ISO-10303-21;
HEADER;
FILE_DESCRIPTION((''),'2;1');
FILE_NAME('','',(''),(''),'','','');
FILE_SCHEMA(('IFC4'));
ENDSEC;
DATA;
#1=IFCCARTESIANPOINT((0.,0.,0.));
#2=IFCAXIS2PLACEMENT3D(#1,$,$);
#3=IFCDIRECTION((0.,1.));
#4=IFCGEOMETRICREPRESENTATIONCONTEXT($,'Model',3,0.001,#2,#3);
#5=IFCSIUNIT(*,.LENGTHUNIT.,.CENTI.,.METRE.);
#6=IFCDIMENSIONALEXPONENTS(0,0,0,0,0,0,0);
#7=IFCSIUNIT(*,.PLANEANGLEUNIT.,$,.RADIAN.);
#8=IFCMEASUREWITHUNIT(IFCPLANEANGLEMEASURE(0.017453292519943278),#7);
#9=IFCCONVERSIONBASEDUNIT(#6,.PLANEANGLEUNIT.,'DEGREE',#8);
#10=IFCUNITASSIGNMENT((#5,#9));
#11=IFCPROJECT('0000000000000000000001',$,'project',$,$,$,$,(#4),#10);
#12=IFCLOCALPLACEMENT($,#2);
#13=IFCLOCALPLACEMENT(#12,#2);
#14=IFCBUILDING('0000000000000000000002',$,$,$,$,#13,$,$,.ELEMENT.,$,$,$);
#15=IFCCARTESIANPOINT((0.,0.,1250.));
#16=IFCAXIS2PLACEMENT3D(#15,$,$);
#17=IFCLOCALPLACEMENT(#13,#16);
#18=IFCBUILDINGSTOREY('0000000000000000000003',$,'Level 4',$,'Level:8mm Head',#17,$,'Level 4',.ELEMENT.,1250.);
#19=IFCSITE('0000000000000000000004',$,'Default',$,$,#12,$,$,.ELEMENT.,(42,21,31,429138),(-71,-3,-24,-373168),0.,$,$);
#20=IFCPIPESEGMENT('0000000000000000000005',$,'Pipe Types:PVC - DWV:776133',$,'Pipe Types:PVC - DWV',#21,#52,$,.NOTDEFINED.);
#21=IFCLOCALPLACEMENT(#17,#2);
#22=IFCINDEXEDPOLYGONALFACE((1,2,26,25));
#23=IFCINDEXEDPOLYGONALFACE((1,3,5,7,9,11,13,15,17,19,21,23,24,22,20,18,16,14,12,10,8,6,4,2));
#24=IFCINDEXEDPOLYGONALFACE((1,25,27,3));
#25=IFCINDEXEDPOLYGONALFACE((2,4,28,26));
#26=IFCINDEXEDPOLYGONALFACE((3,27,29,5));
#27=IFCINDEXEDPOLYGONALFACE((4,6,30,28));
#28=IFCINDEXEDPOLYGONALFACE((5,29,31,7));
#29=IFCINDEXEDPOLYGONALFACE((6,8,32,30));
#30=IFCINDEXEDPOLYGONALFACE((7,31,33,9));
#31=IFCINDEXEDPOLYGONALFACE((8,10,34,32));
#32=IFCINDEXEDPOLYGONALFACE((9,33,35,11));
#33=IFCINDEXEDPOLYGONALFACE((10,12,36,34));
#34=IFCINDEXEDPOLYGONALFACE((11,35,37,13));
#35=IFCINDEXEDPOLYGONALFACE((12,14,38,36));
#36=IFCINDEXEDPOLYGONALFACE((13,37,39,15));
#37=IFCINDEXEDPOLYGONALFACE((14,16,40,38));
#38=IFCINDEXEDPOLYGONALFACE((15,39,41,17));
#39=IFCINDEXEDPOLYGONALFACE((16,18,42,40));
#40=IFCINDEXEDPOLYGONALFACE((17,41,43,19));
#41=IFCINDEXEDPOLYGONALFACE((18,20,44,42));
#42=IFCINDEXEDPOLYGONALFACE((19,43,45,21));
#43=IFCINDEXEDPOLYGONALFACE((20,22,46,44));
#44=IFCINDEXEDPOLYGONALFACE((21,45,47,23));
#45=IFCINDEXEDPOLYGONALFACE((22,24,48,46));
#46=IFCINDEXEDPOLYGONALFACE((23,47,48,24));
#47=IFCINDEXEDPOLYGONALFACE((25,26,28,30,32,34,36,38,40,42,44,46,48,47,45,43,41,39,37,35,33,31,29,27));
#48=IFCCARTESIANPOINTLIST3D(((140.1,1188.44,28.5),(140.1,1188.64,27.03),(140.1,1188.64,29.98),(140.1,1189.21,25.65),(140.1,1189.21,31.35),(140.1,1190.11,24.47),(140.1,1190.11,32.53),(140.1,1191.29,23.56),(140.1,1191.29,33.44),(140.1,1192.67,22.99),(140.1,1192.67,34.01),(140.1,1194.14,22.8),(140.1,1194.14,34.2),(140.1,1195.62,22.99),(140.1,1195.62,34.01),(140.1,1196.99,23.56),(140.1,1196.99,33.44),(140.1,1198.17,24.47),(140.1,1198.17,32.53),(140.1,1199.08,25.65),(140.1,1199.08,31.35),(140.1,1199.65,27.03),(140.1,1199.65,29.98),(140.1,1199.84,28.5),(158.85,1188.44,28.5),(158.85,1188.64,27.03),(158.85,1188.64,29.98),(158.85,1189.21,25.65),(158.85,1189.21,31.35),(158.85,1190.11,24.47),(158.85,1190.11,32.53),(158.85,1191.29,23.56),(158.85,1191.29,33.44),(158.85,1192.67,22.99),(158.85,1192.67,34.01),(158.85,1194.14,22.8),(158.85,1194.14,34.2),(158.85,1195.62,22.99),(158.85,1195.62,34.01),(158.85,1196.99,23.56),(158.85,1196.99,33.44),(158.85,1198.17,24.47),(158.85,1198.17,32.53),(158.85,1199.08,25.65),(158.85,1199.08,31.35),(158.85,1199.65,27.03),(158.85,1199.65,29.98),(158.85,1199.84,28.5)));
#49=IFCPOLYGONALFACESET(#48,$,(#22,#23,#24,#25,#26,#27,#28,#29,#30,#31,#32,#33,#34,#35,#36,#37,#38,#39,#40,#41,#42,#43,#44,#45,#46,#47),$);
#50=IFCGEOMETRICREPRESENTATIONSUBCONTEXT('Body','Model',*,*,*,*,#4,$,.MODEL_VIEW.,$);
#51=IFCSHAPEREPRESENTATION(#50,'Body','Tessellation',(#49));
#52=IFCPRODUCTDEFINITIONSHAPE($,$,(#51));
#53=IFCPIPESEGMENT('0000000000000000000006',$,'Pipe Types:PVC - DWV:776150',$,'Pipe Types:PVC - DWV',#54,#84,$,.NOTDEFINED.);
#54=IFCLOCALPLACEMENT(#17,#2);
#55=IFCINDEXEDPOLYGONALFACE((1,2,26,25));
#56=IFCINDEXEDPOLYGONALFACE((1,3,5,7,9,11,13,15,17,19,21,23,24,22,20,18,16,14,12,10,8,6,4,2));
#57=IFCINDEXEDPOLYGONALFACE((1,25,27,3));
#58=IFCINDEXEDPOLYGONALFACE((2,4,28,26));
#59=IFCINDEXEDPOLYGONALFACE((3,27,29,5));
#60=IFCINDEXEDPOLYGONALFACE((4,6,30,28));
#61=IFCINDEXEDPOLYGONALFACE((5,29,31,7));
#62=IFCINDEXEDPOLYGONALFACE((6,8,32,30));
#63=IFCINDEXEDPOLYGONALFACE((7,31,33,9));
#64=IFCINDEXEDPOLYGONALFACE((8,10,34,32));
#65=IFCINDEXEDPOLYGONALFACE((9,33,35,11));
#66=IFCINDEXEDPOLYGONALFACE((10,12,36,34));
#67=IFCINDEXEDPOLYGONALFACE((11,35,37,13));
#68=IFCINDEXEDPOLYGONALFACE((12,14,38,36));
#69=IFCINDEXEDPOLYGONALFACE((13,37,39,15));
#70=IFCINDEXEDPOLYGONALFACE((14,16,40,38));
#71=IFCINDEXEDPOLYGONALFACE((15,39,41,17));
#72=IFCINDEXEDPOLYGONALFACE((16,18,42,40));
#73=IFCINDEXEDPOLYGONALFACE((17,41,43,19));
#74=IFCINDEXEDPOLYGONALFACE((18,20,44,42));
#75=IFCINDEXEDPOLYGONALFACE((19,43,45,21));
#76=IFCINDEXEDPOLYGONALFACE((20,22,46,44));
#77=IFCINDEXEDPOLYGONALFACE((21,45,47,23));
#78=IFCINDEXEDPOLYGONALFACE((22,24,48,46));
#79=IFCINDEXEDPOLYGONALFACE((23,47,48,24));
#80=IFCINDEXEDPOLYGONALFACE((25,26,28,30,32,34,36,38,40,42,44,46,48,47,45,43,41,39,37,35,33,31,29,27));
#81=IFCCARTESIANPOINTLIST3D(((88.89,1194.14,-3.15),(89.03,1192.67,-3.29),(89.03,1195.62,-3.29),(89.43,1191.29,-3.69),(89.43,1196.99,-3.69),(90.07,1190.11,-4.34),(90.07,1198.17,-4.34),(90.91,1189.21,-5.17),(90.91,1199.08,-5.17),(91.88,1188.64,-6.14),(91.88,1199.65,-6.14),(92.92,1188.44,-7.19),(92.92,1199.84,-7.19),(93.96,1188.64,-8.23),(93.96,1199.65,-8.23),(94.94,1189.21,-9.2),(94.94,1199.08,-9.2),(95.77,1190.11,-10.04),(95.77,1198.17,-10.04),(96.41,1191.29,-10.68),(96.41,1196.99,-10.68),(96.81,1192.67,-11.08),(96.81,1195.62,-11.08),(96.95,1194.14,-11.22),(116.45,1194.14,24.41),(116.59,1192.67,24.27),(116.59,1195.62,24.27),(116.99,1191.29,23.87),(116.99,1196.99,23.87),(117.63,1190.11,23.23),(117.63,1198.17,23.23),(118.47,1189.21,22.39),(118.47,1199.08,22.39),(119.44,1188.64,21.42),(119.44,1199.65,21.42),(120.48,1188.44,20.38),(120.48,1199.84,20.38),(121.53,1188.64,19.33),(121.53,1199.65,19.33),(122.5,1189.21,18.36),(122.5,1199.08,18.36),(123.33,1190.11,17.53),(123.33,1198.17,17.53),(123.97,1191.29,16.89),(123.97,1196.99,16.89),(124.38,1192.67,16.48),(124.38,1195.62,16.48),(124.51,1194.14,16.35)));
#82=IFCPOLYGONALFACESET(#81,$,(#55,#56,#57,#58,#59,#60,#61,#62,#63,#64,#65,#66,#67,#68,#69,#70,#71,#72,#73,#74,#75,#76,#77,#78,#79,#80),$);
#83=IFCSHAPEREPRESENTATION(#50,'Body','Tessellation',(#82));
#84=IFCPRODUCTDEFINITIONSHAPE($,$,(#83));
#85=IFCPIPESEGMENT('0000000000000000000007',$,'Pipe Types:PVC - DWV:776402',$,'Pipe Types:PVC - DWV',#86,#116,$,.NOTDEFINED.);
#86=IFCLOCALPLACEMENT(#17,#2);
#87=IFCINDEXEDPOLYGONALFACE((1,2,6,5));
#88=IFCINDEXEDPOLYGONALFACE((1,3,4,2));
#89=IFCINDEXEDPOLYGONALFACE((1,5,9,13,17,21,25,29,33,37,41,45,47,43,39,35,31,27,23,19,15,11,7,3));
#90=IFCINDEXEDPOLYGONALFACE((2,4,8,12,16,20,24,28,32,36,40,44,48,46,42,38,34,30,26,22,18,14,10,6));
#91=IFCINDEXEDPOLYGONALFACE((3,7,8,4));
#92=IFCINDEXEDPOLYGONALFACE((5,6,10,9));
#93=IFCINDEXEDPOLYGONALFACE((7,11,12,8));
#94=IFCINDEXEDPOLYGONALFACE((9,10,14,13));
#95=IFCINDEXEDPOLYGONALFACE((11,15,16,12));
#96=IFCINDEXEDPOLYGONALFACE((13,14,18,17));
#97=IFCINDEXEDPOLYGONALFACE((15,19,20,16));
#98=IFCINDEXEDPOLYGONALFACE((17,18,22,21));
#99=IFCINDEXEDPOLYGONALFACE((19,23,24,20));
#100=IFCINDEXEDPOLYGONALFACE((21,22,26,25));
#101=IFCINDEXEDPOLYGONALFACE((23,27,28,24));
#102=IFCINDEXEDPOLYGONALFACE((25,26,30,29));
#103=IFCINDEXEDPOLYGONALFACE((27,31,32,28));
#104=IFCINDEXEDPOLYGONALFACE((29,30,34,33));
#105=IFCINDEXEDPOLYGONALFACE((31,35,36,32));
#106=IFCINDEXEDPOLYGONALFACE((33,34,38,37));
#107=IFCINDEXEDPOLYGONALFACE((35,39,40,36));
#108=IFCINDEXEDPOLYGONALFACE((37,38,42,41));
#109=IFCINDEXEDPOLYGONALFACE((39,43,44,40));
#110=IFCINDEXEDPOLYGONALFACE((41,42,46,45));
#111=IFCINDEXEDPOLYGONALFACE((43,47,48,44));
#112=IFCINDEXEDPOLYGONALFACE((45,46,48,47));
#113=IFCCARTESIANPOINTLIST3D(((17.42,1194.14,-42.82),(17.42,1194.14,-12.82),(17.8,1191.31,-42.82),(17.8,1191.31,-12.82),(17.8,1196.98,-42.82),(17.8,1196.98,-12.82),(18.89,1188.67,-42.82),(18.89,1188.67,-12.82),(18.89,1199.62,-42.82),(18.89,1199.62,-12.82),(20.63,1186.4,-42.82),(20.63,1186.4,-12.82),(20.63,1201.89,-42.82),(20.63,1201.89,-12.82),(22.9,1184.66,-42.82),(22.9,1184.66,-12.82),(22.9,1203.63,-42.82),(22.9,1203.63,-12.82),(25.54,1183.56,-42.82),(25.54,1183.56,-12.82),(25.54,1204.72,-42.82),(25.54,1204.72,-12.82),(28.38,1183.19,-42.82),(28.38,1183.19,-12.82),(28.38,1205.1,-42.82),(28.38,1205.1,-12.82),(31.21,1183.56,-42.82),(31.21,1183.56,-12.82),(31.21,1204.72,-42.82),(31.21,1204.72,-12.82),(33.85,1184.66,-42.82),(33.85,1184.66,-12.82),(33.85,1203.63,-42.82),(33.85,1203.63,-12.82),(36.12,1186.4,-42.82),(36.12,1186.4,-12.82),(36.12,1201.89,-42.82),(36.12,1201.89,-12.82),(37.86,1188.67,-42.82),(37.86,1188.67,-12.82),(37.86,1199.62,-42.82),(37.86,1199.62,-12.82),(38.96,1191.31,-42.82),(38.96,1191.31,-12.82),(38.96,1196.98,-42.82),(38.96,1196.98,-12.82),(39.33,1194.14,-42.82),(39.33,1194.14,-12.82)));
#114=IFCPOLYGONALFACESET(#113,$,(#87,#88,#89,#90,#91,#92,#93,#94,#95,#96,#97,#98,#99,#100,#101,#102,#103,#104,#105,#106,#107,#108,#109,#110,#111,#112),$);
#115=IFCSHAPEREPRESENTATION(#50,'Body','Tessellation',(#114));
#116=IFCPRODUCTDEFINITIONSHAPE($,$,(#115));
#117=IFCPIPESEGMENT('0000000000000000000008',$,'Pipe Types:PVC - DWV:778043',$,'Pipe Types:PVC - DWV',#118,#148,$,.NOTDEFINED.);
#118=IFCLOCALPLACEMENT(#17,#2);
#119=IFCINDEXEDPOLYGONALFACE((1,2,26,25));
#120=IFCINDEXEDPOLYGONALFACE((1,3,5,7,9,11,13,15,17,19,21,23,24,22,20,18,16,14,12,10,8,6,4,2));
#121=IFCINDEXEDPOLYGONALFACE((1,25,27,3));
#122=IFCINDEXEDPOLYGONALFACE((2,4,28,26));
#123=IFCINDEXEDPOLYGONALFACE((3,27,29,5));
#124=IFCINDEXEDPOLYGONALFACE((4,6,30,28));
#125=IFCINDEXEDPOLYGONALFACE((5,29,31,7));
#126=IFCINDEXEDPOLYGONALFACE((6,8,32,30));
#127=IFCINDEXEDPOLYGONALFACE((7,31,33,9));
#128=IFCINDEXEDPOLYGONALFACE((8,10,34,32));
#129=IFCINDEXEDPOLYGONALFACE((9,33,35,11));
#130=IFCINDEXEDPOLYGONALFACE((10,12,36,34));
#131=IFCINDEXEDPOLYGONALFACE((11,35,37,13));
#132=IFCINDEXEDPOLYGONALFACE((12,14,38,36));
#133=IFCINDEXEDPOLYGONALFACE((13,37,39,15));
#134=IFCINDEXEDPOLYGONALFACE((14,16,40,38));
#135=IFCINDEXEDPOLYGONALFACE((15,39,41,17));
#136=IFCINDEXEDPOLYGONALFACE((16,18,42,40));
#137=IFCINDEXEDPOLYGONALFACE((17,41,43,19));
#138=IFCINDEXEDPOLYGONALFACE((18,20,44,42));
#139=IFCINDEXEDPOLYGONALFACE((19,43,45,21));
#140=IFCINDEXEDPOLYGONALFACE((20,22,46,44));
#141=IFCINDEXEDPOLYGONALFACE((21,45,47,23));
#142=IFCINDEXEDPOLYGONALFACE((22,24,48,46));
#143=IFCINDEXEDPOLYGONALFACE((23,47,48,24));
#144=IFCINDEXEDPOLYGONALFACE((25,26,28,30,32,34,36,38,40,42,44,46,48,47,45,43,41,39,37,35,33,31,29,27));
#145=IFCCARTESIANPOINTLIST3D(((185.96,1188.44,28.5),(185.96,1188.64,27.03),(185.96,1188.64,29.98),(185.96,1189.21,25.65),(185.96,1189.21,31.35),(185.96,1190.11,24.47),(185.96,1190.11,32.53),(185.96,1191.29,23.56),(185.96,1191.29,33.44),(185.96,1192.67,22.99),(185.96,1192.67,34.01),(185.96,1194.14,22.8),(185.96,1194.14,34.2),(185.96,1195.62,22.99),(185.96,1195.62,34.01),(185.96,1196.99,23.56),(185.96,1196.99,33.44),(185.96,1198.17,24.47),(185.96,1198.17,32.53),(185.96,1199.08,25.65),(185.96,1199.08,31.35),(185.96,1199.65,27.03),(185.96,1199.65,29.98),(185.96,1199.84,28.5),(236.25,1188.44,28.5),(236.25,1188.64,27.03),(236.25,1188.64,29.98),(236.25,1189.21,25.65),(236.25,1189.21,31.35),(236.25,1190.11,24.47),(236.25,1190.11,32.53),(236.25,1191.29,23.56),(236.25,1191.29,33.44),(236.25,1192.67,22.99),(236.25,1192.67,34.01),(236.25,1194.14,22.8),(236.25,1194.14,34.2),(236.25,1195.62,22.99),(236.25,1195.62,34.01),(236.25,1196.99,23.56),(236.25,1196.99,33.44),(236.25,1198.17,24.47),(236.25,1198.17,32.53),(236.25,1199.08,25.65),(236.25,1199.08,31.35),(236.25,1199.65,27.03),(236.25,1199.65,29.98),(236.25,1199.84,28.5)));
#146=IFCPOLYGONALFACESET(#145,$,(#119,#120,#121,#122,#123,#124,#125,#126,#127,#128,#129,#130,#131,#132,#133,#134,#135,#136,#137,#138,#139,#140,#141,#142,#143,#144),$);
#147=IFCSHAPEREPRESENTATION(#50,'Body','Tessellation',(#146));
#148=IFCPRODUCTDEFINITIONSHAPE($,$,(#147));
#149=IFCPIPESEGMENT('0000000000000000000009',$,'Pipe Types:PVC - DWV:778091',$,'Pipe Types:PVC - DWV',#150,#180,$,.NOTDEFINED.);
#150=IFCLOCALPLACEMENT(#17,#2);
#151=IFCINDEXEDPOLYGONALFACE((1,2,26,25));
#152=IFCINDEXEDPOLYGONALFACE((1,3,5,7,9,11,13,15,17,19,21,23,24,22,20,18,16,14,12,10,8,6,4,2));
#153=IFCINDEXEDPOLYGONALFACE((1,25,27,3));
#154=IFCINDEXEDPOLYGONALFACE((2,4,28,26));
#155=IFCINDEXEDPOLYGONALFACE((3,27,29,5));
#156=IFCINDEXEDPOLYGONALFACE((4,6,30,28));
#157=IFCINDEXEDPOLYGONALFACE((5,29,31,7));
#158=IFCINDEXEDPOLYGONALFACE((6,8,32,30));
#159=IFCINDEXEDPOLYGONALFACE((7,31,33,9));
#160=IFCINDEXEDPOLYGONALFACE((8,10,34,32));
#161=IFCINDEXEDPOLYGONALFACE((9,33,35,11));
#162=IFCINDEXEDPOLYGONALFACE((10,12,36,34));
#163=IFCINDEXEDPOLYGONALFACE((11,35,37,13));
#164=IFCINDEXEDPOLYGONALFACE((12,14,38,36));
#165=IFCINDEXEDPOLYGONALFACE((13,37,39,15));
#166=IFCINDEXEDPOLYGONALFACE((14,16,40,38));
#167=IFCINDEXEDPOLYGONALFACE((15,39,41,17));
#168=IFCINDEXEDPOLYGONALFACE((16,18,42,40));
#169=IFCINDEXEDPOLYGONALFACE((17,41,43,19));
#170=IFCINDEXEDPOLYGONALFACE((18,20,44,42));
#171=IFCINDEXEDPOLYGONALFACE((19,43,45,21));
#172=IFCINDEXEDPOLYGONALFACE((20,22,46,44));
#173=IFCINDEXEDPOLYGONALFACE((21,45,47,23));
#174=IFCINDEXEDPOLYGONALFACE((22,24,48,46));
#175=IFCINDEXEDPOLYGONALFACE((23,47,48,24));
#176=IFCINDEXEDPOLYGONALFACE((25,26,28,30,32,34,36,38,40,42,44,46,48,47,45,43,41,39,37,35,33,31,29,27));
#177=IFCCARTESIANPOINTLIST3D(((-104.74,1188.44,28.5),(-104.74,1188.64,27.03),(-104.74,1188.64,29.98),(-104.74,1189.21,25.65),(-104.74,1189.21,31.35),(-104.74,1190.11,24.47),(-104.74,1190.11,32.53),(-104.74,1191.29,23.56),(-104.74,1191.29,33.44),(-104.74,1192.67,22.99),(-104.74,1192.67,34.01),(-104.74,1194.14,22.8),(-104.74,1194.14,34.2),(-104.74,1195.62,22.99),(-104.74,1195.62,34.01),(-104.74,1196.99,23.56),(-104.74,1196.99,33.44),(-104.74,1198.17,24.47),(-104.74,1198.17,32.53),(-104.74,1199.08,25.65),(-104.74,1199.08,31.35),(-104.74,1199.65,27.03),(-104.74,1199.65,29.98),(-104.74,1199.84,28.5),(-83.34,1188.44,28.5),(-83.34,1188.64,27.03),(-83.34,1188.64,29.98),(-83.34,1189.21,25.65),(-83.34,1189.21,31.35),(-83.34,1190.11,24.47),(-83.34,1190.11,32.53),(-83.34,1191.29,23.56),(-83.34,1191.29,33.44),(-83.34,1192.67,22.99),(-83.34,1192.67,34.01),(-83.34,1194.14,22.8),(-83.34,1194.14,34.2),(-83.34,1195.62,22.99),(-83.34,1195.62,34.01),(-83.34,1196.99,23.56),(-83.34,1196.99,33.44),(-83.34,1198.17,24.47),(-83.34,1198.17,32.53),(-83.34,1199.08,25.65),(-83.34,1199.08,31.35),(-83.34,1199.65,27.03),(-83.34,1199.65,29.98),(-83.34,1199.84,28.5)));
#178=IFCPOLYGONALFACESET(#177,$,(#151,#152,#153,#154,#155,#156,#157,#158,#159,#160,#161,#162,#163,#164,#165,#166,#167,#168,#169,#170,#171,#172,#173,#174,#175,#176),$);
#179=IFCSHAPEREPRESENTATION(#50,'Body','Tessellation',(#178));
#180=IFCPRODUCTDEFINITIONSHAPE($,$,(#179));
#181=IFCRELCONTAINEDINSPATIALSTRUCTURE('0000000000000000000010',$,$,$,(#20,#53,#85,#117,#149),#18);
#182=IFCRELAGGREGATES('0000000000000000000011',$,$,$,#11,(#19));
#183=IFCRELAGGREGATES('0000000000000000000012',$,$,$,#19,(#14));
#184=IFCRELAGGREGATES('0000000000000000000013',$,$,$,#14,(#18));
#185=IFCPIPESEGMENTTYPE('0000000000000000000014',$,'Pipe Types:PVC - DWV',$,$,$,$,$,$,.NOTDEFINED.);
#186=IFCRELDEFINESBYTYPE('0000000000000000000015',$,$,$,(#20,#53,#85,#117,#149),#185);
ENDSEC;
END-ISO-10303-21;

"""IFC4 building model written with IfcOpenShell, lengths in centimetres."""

from ifc_helpers import new_model, entity, si_unit, converted_unit, direction, frame, origin, place, context, subcontext, project, spatial, arc, indexed_curve, outline, extrude, type_object, element, save


model = new_model("IFC4")

# Units and contexts
model_context = context("Model", 3, precision=0.001, world=origin(), true_north=direction((0.0, 1.0)))
body_context = subcontext(model_context, "Body", "Model", "MODEL_VIEW")
ifc_project = project(units=[si_unit("LENGTHUNIT", "METRE", prefix="CENTI"), converted_unit("PLANEANGLEUNIT", "DEGREE", entity("IfcPlaneAngleMeasure", 0.017453292519943278), si_unit("PLANEANGLEUNIT", "RADIAN"), dimensions=[0, 0, 0, 0, 0, 0, 0])], contexts=[model_context])

# Site, building, storey
site_placement = place(None, origin())
site = spatial("IfcSite", under=ifc_project, at=site_placement, Name="Default", CompositionType="ELEMENT", RefLatitude=(42, 21, 31, 429138), RefLongitude=(-71, -3, -24, -373168), RefElevation=0.0)
building_placement = place(site_placement, origin())
building = spatial("IfcBuilding", under=site, at=building_placement, CompositionType="ELEMENT")
storey_placement = place(building_placement, frame((0.0, 0.0, 1250.0)))
storey = spatial("IfcBuildingStorey", under=building, at=storey_placement, Name="Level 4", ObjectType="Level:8mm Head", LongName="Level 4", CompositionType="ELEMENT", Elevation=1250.0)

# Pipe segments
pipe_segment_type = type_object("IfcPipeSegmentType", Name="Pipe Types:PVC - DWV", PredefinedType="NOTDEFINED")
pipe_segment_1_placement = place(storey_placement, origin())
element("IfcPipeSegment", 1, at=pipe_segment_1_placement, inside=storey, type_object=pipe_segment_type, Name="Pipe Types:PVC - DWV:776133", ObjectType="Pipe Types:PVC - DWV", PredefinedType="NOTDEFINED", context=body_context, shape_type="SweptSolid", body=[
    extrude(outline(indexed_curve([(5.7, 0.0), (4.03, 4.03), (0.0, 5.7), (-4.03, 4.03), (-5.7, 0.0), (-4.03, -4.03), (0.0, -5.7), (4.03, -4.03)], segments=[arc(1, 2, 3), arc(3, 4, 5), arc(5, 6, 7), arc(7, 8, 1)], self_intersect=False)), frame((140.1, 1194.14, 28.5), z_axis=(1.0, 0.0, 0.0), x_axis=(0.0, 1.0, 0.0)), (0.0, 0.0, 1.0), 18.76),
])
pipe_segment_2_placement = place(storey_placement, origin())
element("IfcPipeSegment", 2, at=pipe_segment_2_placement, inside=storey, type_object=pipe_segment_type, Name="Pipe Types:PVC - DWV:776150", ObjectType="Pipe Types:PVC - DWV", PredefinedType="NOTDEFINED", context=body_context, shape_type="SweptSolid", body=[
    extrude(outline(indexed_curve([(5.7, 0.0), (4.03, 4.03), (0.0, 5.7), (-4.03, 4.03), (-5.7, 0.0), (-4.03, -4.03), (0.0, -5.7), (4.03, -4.03)], segments=[arc(1, 2, 3), arc(3, 4, 5), arc(5, 6, 7), arc(7, 8, 1)], self_intersect=False)), frame((92.92, 1194.14, -7.19), z_axis=(0.707107, 0.0, 0.707107), x_axis=(0.0, -1.0, 0.0)), (0.0, 0.0, 1.0), 38.98),
])
pipe_segment_3_placement = place(storey_placement, origin())
element("IfcPipeSegment", 3, at=pipe_segment_3_placement, inside=storey, type_object=pipe_segment_type, Name="Pipe Types:PVC - DWV:776402", ObjectType="Pipe Types:PVC - DWV", PredefinedType="NOTDEFINED", context=body_context, shape_type="SweptSolid", body=[
    extrude(outline(indexed_curve([(10.95, 0.0), (7.75, 7.75), (0.0, 10.95), (-7.75, 7.75), (-10.95, 0.0), (-7.75, -7.75), (0.0, -10.95), (7.75, -7.75)], segments=[arc(1, 2, 3), arc(3, 4, 5), arc(5, 6, 7), arc(7, 8, 1)], self_intersect=False)), frame((28.38, 1194.14, -42.82), z_axis=(0.0, 0.0, 1.0), x_axis=(-1.0, 0.0, 0.0)), (0.0, 0.0, 1.0), 30.0),
])
pipe_segment_4_placement = place(storey_placement, origin())
element("IfcPipeSegment", 4, at=pipe_segment_4_placement, inside=storey, type_object=pipe_segment_type, Name="Pipe Types:PVC - DWV:778043", ObjectType="Pipe Types:PVC - DWV", PredefinedType="NOTDEFINED", context=body_context, shape_type="SweptSolid", body=[
    extrude(outline(indexed_curve([(5.7, 0.0), (4.03, 4.03), (0.0, 5.7), (-4.03, 4.03), (-5.7, 0.0), (-4.03, -4.03), (0.0, -5.7), (4.03, -4.03)], segments=[arc(1, 2, 3), arc(3, 4, 5), arc(5, 6, 7), arc(7, 8, 1)], self_intersect=False)), frame((185.96, 1194.14, 28.5), z_axis=(1.0, 0.0, 0.0), x_axis=(0.0, 1.0, 0.0)), (0.0, 0.0, 1.0), 50.29),
])
pipe_segment_5_placement = place(storey_placement, origin())
element("IfcPipeSegment", 5, at=pipe_segment_5_placement, inside=storey, type_object=pipe_segment_type, Name="Pipe Types:PVC - DWV:778091", ObjectType="Pipe Types:PVC - DWV", PredefinedType="NOTDEFINED", context=body_context, shape_type="SweptSolid", body=[
    extrude(outline(indexed_curve([(5.7, 0.0), (4.03, 4.03), (0.0, 5.7), (-4.03, 4.03), (-5.7, 0.0), (-4.03, -4.03), (0.0, -5.7), (4.03, -4.03)], segments=[arc(1, 2, 3), arc(3, 4, 5), arc(5, 6, 7), arc(7, 8, 1)], self_intersect=False)), frame((-104.74, 1194.14, 28.5), z_axis=(1.0, 0.0, 0.0), x_axis=(0.0, 1.0, 0.0)), (0.0, 0.0, 1.0), 21.39),
])

save(model, "model.ifc")
